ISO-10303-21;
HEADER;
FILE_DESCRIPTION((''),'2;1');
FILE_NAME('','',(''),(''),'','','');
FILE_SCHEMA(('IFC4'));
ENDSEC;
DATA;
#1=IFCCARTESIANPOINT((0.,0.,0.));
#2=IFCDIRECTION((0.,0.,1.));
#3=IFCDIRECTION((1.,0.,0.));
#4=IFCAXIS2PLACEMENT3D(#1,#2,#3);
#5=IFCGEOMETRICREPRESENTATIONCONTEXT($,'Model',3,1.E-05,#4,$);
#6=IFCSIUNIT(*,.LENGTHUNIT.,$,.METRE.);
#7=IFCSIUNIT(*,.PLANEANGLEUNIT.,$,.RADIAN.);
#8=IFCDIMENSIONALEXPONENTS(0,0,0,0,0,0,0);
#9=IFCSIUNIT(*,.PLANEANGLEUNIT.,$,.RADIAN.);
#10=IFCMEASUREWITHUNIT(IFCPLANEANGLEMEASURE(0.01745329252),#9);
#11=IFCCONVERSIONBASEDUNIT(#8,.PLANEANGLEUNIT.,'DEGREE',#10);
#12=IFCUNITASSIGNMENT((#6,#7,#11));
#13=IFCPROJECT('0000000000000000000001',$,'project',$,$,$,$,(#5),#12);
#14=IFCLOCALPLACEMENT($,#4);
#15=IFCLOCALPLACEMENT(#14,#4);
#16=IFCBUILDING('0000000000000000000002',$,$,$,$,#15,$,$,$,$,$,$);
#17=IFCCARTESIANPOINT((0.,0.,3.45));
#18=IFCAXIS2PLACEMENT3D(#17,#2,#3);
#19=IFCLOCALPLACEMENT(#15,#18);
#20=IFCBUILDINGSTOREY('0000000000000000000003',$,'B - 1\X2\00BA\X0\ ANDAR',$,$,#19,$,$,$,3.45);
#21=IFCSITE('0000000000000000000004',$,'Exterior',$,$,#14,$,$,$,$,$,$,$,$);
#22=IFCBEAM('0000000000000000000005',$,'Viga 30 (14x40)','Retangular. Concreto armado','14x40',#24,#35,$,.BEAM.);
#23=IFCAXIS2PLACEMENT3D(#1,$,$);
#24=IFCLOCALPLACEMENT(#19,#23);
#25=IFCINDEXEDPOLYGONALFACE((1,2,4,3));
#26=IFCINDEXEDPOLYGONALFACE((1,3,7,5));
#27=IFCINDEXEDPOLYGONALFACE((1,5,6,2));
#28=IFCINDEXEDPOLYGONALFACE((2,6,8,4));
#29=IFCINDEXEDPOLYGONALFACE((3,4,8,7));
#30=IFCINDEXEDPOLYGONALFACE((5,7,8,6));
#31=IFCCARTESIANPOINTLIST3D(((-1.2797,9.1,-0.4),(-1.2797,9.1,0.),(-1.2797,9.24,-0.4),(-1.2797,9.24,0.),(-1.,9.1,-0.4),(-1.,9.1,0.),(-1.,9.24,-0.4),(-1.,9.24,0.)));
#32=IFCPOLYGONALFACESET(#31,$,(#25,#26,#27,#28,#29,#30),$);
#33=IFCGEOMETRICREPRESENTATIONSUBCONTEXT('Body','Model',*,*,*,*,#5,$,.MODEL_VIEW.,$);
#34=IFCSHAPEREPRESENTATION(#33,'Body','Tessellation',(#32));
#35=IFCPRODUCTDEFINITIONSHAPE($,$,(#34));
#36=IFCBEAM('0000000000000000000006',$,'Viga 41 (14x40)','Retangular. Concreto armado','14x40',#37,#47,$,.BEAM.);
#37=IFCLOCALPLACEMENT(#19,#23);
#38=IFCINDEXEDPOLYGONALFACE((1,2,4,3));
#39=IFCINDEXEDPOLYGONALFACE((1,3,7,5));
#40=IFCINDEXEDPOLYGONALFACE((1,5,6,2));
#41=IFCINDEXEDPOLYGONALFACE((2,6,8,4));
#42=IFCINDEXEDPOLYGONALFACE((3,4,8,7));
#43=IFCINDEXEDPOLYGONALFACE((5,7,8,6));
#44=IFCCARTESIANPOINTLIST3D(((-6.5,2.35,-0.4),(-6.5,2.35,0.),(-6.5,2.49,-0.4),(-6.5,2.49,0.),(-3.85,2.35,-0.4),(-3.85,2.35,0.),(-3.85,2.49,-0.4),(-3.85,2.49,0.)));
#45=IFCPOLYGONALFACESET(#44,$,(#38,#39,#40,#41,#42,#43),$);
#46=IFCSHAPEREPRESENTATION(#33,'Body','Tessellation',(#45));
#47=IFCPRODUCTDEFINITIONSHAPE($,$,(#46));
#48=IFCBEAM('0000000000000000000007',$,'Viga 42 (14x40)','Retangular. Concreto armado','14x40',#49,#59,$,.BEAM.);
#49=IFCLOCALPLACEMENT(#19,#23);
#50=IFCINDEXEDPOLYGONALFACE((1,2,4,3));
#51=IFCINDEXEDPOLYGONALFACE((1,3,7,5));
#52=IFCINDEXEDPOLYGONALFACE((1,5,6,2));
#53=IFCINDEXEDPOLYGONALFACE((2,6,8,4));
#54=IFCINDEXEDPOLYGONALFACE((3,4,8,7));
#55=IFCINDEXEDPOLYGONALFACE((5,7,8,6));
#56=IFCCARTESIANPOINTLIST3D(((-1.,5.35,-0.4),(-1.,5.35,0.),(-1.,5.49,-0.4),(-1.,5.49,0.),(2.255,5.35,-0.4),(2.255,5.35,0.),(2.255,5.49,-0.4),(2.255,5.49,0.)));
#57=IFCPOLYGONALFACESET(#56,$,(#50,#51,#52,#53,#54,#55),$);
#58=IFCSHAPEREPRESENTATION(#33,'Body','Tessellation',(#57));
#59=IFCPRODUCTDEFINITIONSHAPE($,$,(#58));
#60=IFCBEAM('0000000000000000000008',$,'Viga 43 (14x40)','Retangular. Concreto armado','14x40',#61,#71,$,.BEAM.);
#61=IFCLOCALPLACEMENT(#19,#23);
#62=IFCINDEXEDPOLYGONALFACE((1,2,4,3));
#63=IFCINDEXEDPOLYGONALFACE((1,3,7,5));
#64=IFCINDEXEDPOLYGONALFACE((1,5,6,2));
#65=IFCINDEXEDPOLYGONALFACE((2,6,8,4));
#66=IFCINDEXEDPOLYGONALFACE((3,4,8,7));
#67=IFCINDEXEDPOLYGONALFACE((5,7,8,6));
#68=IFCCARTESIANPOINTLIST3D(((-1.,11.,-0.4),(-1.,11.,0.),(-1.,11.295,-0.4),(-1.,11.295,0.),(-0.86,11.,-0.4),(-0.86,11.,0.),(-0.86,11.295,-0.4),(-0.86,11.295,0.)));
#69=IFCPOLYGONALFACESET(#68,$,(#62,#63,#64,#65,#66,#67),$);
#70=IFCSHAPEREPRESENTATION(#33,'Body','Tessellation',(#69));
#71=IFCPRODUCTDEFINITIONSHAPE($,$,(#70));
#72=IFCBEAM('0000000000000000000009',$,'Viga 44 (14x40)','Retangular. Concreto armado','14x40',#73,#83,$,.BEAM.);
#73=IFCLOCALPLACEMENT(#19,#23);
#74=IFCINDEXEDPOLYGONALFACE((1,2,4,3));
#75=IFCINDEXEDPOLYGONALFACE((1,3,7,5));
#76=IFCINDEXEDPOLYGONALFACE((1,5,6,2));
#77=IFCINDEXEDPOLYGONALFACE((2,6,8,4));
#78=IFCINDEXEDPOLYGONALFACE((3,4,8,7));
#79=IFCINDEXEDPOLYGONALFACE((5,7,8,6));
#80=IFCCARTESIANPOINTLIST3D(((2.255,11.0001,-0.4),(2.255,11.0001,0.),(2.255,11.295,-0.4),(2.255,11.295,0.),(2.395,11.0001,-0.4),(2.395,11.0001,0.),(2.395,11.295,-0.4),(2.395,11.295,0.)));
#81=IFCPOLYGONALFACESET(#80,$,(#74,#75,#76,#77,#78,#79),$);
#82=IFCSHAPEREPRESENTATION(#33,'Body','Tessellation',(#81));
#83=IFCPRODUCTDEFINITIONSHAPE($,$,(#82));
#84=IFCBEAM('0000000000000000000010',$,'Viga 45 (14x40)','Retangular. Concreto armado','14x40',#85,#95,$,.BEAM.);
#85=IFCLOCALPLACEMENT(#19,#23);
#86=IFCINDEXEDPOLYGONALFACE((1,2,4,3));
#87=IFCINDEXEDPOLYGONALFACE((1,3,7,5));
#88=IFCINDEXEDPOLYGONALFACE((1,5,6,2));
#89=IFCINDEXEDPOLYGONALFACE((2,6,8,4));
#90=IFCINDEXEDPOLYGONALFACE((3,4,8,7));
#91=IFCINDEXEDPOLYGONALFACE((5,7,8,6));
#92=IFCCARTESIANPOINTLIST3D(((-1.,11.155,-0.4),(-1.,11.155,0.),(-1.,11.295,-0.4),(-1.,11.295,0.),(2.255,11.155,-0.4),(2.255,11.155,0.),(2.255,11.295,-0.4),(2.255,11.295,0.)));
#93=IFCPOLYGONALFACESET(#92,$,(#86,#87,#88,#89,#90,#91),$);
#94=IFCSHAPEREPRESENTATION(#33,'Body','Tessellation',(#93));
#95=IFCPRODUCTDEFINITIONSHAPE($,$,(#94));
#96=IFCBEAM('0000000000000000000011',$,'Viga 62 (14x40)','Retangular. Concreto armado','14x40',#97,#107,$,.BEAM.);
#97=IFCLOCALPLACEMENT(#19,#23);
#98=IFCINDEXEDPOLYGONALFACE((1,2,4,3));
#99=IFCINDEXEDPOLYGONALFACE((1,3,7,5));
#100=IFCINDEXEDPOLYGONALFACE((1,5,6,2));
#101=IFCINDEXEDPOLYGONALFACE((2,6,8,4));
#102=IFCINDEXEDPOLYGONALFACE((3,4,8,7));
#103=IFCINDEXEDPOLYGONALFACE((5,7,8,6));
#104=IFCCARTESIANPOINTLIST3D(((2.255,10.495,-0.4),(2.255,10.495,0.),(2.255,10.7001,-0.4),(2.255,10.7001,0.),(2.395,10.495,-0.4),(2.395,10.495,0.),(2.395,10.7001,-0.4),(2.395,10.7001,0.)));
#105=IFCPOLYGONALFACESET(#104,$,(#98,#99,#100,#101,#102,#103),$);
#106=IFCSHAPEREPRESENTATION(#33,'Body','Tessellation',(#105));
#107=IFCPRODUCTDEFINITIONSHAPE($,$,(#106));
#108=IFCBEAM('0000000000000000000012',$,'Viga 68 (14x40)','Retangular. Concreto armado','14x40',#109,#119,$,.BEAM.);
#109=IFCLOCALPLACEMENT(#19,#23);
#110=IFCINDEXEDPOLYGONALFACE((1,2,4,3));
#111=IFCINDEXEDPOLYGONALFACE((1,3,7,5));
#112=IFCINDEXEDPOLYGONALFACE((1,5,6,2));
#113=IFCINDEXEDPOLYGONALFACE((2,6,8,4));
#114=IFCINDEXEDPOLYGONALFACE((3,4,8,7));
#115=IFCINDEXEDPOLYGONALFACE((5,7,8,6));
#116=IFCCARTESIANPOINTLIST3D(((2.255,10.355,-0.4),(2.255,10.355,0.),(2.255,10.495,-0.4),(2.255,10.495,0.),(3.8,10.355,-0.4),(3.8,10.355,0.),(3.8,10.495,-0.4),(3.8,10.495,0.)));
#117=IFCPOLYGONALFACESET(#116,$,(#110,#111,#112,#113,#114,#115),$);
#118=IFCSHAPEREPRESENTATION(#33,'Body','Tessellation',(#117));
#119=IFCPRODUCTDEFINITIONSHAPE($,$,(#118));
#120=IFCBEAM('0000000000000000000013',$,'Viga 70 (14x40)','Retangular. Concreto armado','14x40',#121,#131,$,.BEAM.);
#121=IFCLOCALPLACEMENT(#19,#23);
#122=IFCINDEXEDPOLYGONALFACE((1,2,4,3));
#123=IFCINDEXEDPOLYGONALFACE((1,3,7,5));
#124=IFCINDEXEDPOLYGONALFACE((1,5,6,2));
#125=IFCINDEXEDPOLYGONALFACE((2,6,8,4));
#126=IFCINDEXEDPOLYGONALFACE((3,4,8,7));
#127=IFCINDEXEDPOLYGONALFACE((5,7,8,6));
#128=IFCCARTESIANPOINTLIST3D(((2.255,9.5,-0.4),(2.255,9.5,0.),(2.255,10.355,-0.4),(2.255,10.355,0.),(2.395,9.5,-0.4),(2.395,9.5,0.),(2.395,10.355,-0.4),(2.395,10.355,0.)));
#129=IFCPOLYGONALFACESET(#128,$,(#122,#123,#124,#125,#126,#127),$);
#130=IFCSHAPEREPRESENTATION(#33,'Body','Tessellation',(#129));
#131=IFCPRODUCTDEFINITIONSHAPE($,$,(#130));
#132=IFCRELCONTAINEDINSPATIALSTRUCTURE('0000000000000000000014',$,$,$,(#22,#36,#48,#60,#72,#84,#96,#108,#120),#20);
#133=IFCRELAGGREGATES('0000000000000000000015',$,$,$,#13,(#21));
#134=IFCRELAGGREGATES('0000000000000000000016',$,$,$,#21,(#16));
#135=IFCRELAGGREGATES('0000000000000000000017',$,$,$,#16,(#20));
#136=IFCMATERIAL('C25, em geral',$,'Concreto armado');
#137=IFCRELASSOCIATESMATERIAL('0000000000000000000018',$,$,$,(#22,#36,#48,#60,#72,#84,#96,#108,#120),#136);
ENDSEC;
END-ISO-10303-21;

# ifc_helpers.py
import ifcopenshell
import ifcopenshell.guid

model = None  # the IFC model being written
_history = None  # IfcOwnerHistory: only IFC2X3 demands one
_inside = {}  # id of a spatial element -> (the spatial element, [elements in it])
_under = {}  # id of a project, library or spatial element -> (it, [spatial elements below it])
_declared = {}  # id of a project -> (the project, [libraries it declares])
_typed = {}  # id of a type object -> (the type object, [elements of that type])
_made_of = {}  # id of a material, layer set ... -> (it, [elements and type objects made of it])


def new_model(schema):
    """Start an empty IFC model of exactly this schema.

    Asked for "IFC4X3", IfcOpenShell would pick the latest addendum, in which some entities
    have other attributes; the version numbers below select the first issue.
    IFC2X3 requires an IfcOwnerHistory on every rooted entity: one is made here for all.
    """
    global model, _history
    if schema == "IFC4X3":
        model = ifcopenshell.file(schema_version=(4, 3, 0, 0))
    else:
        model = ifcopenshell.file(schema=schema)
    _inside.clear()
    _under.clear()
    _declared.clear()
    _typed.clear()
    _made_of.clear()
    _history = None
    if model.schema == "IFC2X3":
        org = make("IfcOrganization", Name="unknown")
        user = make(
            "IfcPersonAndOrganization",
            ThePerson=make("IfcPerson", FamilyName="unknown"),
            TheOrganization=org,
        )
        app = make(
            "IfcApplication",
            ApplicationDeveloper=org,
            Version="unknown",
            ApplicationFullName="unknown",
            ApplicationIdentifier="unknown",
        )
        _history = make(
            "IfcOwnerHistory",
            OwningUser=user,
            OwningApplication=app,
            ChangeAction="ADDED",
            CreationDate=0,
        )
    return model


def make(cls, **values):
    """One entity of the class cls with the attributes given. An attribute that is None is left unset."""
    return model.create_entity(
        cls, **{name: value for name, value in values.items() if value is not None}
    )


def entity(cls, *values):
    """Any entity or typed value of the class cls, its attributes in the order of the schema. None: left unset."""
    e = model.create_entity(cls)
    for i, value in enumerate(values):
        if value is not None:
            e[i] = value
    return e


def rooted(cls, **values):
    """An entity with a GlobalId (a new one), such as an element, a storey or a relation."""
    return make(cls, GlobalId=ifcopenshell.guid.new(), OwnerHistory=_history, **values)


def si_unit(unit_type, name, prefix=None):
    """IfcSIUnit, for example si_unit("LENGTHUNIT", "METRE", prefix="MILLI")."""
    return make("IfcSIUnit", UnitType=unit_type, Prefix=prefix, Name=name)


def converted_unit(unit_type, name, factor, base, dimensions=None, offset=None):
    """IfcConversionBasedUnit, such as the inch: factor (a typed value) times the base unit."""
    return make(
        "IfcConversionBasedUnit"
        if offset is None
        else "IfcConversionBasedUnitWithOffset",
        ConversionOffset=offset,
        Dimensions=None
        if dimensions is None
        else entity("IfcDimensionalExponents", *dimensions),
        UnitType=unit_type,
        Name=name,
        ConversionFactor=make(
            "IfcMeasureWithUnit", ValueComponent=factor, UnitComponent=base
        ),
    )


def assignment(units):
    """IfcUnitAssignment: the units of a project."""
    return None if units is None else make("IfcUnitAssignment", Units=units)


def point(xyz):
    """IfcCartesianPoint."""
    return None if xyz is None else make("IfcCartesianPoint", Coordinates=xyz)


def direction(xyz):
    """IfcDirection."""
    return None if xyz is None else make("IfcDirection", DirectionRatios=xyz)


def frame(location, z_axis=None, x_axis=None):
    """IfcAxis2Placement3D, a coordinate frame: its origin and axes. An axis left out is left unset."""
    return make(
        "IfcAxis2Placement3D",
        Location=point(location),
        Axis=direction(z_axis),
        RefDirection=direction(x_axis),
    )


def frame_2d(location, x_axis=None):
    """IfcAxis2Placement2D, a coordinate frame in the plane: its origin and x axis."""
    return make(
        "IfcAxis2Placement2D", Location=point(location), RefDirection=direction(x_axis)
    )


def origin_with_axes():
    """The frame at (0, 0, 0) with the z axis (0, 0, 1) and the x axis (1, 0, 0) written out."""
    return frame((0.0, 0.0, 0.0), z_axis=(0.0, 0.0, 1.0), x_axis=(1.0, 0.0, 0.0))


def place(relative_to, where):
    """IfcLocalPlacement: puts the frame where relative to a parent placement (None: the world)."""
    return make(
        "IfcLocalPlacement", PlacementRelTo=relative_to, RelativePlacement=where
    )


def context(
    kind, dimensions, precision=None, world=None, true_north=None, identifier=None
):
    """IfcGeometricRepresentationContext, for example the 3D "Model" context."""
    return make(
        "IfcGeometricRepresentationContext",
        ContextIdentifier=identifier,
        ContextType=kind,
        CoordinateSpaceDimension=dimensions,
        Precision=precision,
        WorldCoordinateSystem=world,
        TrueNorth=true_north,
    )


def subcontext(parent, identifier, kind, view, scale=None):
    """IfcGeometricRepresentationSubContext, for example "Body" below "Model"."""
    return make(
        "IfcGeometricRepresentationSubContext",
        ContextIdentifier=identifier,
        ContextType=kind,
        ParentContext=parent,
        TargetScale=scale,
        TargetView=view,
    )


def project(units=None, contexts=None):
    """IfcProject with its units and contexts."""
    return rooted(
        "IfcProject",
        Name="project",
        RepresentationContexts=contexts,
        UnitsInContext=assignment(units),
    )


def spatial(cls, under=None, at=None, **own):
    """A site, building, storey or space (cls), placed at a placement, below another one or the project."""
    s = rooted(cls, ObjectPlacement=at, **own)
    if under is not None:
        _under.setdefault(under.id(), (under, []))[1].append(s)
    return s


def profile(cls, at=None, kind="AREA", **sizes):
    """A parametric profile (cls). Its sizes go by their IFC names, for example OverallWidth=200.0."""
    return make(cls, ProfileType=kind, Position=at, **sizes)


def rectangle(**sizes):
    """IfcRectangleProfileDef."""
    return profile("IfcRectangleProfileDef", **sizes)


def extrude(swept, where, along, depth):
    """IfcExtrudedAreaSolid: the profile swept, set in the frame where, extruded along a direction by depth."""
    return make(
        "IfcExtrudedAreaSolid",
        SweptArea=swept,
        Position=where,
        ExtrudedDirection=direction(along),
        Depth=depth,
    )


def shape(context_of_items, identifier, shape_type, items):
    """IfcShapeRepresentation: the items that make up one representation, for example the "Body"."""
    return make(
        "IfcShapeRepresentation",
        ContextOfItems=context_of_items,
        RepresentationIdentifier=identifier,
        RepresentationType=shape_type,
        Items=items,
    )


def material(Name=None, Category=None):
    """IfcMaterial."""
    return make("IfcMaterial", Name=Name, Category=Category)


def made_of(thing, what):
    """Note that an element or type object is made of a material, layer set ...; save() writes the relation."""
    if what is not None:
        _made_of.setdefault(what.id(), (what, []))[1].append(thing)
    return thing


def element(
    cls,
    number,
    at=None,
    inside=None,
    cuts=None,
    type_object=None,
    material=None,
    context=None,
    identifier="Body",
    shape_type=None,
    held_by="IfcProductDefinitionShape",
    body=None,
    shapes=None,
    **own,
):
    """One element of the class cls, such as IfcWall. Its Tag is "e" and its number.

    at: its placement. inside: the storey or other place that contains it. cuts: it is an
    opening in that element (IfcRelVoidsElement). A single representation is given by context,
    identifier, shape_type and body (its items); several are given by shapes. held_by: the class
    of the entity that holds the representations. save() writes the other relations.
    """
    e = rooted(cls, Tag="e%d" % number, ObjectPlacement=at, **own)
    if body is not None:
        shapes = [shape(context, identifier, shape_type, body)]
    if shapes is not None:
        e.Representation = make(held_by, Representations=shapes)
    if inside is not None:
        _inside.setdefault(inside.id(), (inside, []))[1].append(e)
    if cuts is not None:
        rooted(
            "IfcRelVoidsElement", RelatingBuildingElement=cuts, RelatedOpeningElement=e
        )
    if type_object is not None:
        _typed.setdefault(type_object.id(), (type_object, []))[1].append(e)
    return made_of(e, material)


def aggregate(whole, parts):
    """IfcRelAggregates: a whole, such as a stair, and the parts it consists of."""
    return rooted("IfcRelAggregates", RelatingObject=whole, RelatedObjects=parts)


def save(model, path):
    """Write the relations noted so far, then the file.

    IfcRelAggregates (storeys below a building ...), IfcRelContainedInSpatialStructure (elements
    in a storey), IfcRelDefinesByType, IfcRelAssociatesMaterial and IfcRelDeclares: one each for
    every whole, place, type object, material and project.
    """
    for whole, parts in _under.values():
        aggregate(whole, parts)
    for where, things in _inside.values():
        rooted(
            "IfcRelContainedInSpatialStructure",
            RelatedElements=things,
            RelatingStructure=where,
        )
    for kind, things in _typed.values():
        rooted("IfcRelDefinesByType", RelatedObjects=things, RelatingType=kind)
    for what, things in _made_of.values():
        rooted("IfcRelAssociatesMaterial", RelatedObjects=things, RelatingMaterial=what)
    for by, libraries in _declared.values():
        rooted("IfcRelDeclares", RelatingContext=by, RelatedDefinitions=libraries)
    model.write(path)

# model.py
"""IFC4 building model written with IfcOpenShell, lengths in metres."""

from ifc_helpers import new_model, entity, si_unit, converted_unit, frame, frame_2d, origin_with_axes, place, context, subcontext, project, spatial, rectangle, extrude, material, element, save


model = new_model("IFC4")

# Units and contexts
model_context = context("Model", 3, precision=1e-05, world=origin_with_axes())
body_context = subcontext(model_context, "Body", "Model", "MODEL_VIEW")
ifc_project = project(units=[si_unit("LENGTHUNIT", "METRE"), si_unit("PLANEANGLEUNIT", "RADIAN"), converted_unit("PLANEANGLEUNIT", "DEGREE", entity("IfcPlaneAngleMeasure", 0.01745329252), si_unit("PLANEANGLEUNIT", "RADIAN"), dimensions=[0, 0, 0, 0, 0, 0, 0])], contexts=[model_context])

# Site, building, storey
site_placement = place(None, origin_with_axes())
site = spatial("IfcSite", under=ifc_project, at=site_placement, Name="Exterior")
building_placement = place(site_placement, origin_with_axes())
building = spatial("IfcBuilding", under=site, at=building_placement)
storey_placement = place(building_placement, frame((0.0, 0.0, 3.45), z_axis=(0.0, 0.0, 1.0), x_axis=(1.0, 0.0, 0.0)))
storey = spatial("IfcBuildingStorey", under=building, at=storey_placement, Name="B - 1º ANDAR", Elevation=3.45)

# Shared definitions
ifc_material = material(Name="C25, em geral", Category="Concreto armado")

# Beams
beam_1_placement = place(storey_placement, frame((-1.0, 9.17, 0.0), z_axis=(-1.0, 0.0, 0.0), x_axis=(0.0, -1.0, 0.0)))
element("IfcBeam", 1, at=beam_1_placement, inside=storey, material=ifc_material, Name="Viga 30 (14x40)", Description="Retangular. Concreto armado", ObjectType="14x40", PredefinedType="BEAM", context=body_context, shape_type="SweptSolid", body=[
    extrude(rectangle(XDim=0.14, YDim=0.4, at=frame_2d((0.0, -0.2), x_axis=(1.0, 0.0))), origin_with_axes(), (0.0, 0.0, 1.0), 0.2797),
])
beam_2_placement = place(storey_placement, frame((-6.5, 2.42, 0.0), z_axis=(1.0, 0.0, 0.0), x_axis=(0.0, 1.0, 0.0)))
element("IfcBeam", 2, at=beam_2_placement, inside=storey, material=ifc_material, Name="Viga 41 (14x40)", Description="Retangular. Concreto armado", ObjectType="14x40", PredefinedType="BEAM", context=body_context, shape_type="SweptSolid", body=[
    extrude(rectangle(XDim=0.14, YDim=0.4, at=frame_2d((0.0, -0.2), x_axis=(1.0, 0.0))), origin_with_axes(), (0.0, 0.0, 1.0), 2.65),
])
beam_3_placement = place(storey_placement, frame((-1.0, 5.42, 0.0), z_axis=(1.0, 0.0, 0.0), x_axis=(0.0, 1.0, 0.0)))
element("IfcBeam", 3, at=beam_3_placement, inside=storey, material=ifc_material, Name="Viga 42 (14x40)", Description="Retangular. Concreto armado", ObjectType="14x40", PredefinedType="BEAM", context=body_context, shape_type="SweptSolid", body=[
    extrude(rectangle(XDim=0.14, YDim=0.4, at=frame_2d((0.0, -0.2), x_axis=(1.0, 0.0))), origin_with_axes(), (0.0, 0.0, 1.0), 3.255),
])
beam_4_placement = place(storey_placement, frame((-0.93, 11.0, 0.0), z_axis=(0.0, 1.0, 0.0), x_axis=(-1.0, 0.0, 0.0)))
element("IfcBeam", 4, at=beam_4_placement, inside=storey, material=ifc_material, Name="Viga 43 (14x40)", Description="Retangular. Concreto armado", ObjectType="14x40", PredefinedType="BEAM", context=body_context, shape_type="SweptSolid", body=[
    extrude(rectangle(XDim=0.14, YDim=0.4, at=frame_2d((0.0, -0.2), x_axis=(1.0, 0.0))), origin_with_axes(), (0.0, 0.0, 1.0), 0.295),
])
beam_5_placement = place(storey_placement, frame((2.325, 11.0001, 0.0), z_axis=(0.0, 1.0, 0.0), x_axis=(-1.0, 0.0, 0.0)))
element("IfcBeam", 5, at=beam_5_placement, inside=storey, material=ifc_material, Name="Viga 44 (14x40)", Description="Retangular. Concreto armado", ObjectType="14x40", PredefinedType="BEAM", context=body_context, shape_type="SweptSolid", body=[
    extrude(rectangle(XDim=0.14, YDim=0.4, at=frame_2d((0.0, -0.2), x_axis=(1.0, 0.0))), origin_with_axes(), (0.0, 0.0, 1.0), 0.2949),
])
beam_6_placement = place(storey_placement, frame((-1.0, 11.225, 0.0), z_axis=(1.0, 0.0, 0.0), x_axis=(0.0, 1.0, 0.0)))
element("IfcBeam", 6, at=beam_6_placement, inside=storey, material=ifc_material, Name="Viga 45 (14x40)", Description="Retangular. Concreto armado", ObjectType="14x40", PredefinedType="BEAM", context=body_context, shape_type="SweptSolid", body=[
    extrude(rectangle(XDim=0.14, YDim=0.4, at=frame_2d((0.0, -0.2), x_axis=(1.0, 0.0))), origin_with_axes(), (0.0, 0.0, 1.0), 3.255),
])
beam_7_placement = place(storey_placement, frame((2.325, 10.7001, 0.0), z_axis=(0.0, -1.0, 0.0), x_axis=(1.0, 0.0, 0.0)))
element("IfcBeam", 7, at=beam_7_placement, inside=storey, material=ifc_material, Name="Viga 62 (14x40)", Description="Retangular. Concreto armado", ObjectType="14x40", PredefinedType="BEAM", context=body_context, shape_type="SweptSolid", body=[
    extrude(rectangle(XDim=0.14, YDim=0.4, at=frame_2d((0.0, -0.2), x_axis=(1.0, 0.0))), origin_with_axes(), (0.0, 0.0, 1.0), 0.2051),
])
beam_8_placement = place(storey_placement, frame((2.255, 10.425, 0.0), z_axis=(1.0, 0.0, 0.0), x_axis=(0.0, 1.0, 0.0)))
element("IfcBeam", 8, at=beam_8_placement, inside=storey, material=ifc_material, Name="Viga 68 (14x40)", Description="Retangular. Concreto armado", ObjectType="14x40", PredefinedType="BEAM", context=body_context, shape_type="SweptSolid", body=[
    extrude(rectangle(XDim=0.14, YDim=0.4, at=frame_2d((0.0, -0.2), x_axis=(1.0, 0.0))), origin_with_axes(), (0.0, 0.0, 1.0), 1.545),
])
beam_9_placement = place(storey_placement, frame((2.325, 10.355, 0.0), z_axis=(0.0, -1.0, 0.0), x_axis=(1.0, 0.0, 0.0)))
element("IfcBeam", 9, at=beam_9_placement, inside=storey, material=ifc_material, Name="Viga 70 (14x40)", Description="Retangular. Concreto armado", ObjectType="14x40", PredefinedType="BEAM", context=body_context, shape_type="SweptSolid", body=[
    extrude(rectangle(XDim=0.14, YDim=0.4, at=frame_2d((0.0, -0.2), x_axis=(1.0, 0.0))), origin_with_axes(), (0.0, 0.0, 1.0), 0.855),
])

save(model, "model.ifc")
